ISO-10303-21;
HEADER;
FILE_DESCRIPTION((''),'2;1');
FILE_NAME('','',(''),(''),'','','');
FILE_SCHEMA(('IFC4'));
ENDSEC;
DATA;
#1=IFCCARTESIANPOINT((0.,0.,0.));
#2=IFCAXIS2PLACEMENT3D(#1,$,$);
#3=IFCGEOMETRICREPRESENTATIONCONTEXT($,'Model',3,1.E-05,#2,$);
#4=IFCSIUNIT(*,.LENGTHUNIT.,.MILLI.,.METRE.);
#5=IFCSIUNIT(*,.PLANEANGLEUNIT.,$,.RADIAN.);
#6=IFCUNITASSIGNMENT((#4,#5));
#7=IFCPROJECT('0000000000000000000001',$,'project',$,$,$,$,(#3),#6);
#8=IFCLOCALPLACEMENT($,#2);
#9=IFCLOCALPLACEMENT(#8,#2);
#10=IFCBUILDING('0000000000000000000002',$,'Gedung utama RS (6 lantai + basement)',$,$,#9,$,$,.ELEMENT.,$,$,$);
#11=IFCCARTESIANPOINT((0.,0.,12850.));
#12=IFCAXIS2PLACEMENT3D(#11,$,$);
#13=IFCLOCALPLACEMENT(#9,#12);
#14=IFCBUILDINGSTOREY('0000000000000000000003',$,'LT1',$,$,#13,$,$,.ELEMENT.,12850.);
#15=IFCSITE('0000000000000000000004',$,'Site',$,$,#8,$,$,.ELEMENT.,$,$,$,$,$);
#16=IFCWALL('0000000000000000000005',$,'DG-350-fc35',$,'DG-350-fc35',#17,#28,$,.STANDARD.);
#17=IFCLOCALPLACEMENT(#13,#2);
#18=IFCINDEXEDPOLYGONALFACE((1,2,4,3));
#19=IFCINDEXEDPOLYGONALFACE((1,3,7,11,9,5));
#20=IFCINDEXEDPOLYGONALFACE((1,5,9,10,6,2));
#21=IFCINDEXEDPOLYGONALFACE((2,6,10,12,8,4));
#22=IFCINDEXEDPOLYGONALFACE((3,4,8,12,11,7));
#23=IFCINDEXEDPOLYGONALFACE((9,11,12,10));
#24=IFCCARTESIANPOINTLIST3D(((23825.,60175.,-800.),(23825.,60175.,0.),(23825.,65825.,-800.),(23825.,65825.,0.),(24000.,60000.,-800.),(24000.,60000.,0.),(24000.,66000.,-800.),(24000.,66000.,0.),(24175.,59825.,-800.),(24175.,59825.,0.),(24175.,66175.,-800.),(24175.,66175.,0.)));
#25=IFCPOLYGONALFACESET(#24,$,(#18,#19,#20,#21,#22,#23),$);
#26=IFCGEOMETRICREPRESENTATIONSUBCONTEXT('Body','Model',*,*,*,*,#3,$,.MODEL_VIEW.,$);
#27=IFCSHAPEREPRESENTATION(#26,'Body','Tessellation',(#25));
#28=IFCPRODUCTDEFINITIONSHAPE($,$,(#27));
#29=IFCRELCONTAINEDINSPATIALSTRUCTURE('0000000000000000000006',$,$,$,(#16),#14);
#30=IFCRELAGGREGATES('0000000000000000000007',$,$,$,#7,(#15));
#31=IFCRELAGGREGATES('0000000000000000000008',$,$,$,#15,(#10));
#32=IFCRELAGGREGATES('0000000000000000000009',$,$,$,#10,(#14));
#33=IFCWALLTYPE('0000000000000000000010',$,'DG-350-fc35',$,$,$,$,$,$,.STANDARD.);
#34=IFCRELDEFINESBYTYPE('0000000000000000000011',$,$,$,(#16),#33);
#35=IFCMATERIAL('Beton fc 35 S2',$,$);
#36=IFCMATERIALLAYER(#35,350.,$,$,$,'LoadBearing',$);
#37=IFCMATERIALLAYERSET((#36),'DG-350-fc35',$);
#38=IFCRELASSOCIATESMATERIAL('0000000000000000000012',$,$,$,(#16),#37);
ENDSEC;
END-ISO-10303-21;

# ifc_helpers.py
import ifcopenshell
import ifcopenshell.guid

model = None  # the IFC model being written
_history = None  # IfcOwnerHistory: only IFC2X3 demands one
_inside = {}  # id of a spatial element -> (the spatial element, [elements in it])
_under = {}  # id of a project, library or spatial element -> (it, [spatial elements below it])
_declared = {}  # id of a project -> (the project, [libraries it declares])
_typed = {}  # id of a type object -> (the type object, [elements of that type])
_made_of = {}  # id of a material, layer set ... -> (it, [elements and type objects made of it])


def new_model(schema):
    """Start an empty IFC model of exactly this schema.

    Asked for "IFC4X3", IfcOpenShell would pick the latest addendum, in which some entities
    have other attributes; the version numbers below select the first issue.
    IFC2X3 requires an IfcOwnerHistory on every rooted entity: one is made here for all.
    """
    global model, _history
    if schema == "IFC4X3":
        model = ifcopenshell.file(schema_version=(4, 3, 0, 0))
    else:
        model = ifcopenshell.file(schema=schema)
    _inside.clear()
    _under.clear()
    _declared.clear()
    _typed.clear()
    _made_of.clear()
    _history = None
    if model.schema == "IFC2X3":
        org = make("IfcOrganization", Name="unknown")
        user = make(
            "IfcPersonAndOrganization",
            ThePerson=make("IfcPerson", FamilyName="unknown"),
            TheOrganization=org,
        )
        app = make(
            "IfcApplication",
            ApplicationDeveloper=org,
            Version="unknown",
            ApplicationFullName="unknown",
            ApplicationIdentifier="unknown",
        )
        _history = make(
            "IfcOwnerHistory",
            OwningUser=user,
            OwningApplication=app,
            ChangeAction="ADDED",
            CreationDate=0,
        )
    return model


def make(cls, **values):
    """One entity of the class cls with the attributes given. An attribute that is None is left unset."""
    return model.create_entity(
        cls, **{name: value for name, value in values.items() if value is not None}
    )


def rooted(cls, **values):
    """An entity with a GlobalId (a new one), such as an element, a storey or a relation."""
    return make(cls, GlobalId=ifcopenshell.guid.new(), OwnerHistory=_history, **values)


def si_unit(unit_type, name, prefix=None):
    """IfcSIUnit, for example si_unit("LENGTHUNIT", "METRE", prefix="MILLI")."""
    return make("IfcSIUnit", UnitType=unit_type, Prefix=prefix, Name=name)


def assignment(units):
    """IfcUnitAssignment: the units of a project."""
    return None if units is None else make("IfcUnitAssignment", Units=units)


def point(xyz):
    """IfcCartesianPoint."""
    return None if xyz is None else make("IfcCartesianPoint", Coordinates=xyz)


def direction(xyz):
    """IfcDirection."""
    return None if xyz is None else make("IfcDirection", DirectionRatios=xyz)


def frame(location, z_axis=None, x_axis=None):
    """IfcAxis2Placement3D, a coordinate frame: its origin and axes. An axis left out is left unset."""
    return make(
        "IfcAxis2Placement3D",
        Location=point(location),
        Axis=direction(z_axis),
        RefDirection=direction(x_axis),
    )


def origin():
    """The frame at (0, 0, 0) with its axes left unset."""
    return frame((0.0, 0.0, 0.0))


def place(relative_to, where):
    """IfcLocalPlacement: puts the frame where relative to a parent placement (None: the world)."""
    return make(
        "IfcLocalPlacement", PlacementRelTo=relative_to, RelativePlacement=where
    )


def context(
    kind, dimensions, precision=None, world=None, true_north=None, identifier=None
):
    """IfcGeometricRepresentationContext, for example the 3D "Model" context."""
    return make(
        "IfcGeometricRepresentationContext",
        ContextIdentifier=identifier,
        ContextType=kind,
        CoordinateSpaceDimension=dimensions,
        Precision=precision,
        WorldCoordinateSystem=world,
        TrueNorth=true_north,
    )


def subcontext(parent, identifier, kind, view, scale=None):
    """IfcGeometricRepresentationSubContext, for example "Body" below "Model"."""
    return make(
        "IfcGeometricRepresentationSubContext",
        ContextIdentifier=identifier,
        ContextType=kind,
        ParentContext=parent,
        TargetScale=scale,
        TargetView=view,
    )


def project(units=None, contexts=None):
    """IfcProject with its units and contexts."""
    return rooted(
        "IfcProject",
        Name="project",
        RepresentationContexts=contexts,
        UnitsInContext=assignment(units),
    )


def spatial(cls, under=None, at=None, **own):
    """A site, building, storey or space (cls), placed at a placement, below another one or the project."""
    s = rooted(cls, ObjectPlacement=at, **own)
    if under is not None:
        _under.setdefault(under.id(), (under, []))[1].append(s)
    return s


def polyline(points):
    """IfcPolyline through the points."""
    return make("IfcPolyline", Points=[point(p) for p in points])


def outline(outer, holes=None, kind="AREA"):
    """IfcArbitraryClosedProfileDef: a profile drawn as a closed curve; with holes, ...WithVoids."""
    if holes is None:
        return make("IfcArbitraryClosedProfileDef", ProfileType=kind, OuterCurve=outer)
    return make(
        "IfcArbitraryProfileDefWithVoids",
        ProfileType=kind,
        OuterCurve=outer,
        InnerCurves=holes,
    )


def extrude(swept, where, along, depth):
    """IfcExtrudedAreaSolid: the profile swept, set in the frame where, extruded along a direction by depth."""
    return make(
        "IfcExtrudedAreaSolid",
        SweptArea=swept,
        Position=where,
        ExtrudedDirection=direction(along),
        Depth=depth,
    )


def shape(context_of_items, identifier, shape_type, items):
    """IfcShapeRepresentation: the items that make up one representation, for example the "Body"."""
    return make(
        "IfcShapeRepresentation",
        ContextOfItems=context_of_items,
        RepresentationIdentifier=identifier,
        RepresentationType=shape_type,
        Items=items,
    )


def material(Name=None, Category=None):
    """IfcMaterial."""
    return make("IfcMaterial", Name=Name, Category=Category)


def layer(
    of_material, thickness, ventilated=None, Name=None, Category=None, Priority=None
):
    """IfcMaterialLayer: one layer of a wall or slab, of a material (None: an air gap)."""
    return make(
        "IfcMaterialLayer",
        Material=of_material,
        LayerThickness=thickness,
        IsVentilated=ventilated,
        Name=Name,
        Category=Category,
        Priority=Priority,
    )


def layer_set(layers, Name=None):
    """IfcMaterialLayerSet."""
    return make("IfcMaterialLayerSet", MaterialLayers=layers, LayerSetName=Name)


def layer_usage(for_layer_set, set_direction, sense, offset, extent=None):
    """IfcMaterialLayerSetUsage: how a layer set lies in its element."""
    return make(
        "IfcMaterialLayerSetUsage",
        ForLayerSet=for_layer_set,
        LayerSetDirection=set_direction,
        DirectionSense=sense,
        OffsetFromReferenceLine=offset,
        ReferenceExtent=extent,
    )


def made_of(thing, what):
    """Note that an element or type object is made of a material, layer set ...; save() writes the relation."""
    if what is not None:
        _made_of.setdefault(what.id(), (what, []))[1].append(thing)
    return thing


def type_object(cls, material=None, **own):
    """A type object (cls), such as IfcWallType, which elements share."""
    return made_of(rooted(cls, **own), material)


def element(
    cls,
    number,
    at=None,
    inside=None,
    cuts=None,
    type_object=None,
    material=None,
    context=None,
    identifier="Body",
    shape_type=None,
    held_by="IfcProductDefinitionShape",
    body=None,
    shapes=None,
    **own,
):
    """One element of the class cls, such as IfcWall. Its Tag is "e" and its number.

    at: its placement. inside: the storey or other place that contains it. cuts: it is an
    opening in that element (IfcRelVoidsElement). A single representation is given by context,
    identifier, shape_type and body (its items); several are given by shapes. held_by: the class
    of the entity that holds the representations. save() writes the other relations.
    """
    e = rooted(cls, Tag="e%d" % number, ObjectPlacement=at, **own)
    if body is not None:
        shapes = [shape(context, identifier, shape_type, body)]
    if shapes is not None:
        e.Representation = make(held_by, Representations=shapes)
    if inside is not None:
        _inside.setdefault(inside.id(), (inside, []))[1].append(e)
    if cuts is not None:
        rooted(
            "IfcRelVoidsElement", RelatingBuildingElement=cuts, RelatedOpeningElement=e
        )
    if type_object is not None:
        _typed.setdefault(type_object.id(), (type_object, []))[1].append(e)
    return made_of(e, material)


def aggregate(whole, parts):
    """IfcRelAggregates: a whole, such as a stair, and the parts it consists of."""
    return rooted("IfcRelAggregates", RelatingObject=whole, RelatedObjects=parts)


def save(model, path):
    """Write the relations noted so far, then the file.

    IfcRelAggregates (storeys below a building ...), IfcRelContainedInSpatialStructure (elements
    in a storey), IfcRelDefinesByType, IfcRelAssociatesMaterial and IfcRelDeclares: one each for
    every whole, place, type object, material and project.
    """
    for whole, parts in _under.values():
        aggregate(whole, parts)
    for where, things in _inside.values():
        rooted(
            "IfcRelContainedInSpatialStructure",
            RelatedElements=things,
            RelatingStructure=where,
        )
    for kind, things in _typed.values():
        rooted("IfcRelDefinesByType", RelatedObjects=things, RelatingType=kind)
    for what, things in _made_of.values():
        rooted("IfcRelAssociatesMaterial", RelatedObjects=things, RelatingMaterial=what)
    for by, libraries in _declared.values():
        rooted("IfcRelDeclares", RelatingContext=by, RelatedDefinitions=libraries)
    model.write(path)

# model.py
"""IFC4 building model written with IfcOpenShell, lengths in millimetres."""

from ifc_helpers import new_model, si_unit, frame, origin, place, context, subcontext, project, spatial, polyline, outline, extrude, material, layer, layer_set, layer_usage, type_object, element, save


model = new_model("IFC4")

# Units and contexts
model_context = context("Model", 3, precision=1e-05, world=origin())
body_context = subcontext(model_context, "Body", "Model", "MODEL_VIEW")
ifc_project = project(units=[si_unit("LENGTHUNIT", "METRE", prefix="MILLI"), si_unit("PLANEANGLEUNIT", "RADIAN")], contexts=[model_context])

# Site, building, storey
site_placement = place(None, origin())
site = spatial("IfcSite", under=ifc_project, at=site_placement, Name="Site", CompositionType="ELEMENT")
building_placement = place(site_placement, origin())
building = spatial("IfcBuilding", under=site, at=building_placement, Name="Gedung utama RS (6 lantai + basement)", CompositionType="ELEMENT")
storey_placement = place(building_placement, frame((0.0, 0.0, 12850.0)))
storey = spatial("IfcBuildingStorey", under=building, at=storey_placement, Name="LT1", CompositionType="ELEMENT", Elevation=12850.0)

# Shared definitions
ifc_material = material(Name="Beton fc 35 S2")

# Wall
ifc_layer = layer(ifc_material, 350.0, Category="LoadBearing")
ifc_layer_set = layer_set([ifc_layer], Name="DG-350-fc35")
ifc_layer_usage = layer_usage(ifc_layer_set, "AXIS2", "NEGATIVE", 175.0)
wall_type = type_object("IfcWallType", Name="DG-350-fc35", PredefinedType="STANDARD")
wall_1_placement = place(storey_placement, frame((24000.0, 60000.0, -800.0), z_axis=(0.0, 0.0, 1.0), x_axis=(0.0, 1.0, 0.0)))
element("IfcWall", 1, at=wall_1_placement, inside=storey, type_object=wall_type, material=ifc_layer_usage, Name="DG-350-fc35", ObjectType="DG-350-fc35", PredefinedType="STANDARD", context=body_context, shape_type="SweptSolid", body=[
    extrude(outline(polyline([(-175.0, -175.0), (0.0, 0.0), (175.0, 175.0), (5825.0, 175.0), (6000.0, 0.0), (6175.0, -175.0), (-175.0, -175.0)])), origin(), (0.0, 0.0, 1.0), 800.0),
])

save(model, "model.ifc")
